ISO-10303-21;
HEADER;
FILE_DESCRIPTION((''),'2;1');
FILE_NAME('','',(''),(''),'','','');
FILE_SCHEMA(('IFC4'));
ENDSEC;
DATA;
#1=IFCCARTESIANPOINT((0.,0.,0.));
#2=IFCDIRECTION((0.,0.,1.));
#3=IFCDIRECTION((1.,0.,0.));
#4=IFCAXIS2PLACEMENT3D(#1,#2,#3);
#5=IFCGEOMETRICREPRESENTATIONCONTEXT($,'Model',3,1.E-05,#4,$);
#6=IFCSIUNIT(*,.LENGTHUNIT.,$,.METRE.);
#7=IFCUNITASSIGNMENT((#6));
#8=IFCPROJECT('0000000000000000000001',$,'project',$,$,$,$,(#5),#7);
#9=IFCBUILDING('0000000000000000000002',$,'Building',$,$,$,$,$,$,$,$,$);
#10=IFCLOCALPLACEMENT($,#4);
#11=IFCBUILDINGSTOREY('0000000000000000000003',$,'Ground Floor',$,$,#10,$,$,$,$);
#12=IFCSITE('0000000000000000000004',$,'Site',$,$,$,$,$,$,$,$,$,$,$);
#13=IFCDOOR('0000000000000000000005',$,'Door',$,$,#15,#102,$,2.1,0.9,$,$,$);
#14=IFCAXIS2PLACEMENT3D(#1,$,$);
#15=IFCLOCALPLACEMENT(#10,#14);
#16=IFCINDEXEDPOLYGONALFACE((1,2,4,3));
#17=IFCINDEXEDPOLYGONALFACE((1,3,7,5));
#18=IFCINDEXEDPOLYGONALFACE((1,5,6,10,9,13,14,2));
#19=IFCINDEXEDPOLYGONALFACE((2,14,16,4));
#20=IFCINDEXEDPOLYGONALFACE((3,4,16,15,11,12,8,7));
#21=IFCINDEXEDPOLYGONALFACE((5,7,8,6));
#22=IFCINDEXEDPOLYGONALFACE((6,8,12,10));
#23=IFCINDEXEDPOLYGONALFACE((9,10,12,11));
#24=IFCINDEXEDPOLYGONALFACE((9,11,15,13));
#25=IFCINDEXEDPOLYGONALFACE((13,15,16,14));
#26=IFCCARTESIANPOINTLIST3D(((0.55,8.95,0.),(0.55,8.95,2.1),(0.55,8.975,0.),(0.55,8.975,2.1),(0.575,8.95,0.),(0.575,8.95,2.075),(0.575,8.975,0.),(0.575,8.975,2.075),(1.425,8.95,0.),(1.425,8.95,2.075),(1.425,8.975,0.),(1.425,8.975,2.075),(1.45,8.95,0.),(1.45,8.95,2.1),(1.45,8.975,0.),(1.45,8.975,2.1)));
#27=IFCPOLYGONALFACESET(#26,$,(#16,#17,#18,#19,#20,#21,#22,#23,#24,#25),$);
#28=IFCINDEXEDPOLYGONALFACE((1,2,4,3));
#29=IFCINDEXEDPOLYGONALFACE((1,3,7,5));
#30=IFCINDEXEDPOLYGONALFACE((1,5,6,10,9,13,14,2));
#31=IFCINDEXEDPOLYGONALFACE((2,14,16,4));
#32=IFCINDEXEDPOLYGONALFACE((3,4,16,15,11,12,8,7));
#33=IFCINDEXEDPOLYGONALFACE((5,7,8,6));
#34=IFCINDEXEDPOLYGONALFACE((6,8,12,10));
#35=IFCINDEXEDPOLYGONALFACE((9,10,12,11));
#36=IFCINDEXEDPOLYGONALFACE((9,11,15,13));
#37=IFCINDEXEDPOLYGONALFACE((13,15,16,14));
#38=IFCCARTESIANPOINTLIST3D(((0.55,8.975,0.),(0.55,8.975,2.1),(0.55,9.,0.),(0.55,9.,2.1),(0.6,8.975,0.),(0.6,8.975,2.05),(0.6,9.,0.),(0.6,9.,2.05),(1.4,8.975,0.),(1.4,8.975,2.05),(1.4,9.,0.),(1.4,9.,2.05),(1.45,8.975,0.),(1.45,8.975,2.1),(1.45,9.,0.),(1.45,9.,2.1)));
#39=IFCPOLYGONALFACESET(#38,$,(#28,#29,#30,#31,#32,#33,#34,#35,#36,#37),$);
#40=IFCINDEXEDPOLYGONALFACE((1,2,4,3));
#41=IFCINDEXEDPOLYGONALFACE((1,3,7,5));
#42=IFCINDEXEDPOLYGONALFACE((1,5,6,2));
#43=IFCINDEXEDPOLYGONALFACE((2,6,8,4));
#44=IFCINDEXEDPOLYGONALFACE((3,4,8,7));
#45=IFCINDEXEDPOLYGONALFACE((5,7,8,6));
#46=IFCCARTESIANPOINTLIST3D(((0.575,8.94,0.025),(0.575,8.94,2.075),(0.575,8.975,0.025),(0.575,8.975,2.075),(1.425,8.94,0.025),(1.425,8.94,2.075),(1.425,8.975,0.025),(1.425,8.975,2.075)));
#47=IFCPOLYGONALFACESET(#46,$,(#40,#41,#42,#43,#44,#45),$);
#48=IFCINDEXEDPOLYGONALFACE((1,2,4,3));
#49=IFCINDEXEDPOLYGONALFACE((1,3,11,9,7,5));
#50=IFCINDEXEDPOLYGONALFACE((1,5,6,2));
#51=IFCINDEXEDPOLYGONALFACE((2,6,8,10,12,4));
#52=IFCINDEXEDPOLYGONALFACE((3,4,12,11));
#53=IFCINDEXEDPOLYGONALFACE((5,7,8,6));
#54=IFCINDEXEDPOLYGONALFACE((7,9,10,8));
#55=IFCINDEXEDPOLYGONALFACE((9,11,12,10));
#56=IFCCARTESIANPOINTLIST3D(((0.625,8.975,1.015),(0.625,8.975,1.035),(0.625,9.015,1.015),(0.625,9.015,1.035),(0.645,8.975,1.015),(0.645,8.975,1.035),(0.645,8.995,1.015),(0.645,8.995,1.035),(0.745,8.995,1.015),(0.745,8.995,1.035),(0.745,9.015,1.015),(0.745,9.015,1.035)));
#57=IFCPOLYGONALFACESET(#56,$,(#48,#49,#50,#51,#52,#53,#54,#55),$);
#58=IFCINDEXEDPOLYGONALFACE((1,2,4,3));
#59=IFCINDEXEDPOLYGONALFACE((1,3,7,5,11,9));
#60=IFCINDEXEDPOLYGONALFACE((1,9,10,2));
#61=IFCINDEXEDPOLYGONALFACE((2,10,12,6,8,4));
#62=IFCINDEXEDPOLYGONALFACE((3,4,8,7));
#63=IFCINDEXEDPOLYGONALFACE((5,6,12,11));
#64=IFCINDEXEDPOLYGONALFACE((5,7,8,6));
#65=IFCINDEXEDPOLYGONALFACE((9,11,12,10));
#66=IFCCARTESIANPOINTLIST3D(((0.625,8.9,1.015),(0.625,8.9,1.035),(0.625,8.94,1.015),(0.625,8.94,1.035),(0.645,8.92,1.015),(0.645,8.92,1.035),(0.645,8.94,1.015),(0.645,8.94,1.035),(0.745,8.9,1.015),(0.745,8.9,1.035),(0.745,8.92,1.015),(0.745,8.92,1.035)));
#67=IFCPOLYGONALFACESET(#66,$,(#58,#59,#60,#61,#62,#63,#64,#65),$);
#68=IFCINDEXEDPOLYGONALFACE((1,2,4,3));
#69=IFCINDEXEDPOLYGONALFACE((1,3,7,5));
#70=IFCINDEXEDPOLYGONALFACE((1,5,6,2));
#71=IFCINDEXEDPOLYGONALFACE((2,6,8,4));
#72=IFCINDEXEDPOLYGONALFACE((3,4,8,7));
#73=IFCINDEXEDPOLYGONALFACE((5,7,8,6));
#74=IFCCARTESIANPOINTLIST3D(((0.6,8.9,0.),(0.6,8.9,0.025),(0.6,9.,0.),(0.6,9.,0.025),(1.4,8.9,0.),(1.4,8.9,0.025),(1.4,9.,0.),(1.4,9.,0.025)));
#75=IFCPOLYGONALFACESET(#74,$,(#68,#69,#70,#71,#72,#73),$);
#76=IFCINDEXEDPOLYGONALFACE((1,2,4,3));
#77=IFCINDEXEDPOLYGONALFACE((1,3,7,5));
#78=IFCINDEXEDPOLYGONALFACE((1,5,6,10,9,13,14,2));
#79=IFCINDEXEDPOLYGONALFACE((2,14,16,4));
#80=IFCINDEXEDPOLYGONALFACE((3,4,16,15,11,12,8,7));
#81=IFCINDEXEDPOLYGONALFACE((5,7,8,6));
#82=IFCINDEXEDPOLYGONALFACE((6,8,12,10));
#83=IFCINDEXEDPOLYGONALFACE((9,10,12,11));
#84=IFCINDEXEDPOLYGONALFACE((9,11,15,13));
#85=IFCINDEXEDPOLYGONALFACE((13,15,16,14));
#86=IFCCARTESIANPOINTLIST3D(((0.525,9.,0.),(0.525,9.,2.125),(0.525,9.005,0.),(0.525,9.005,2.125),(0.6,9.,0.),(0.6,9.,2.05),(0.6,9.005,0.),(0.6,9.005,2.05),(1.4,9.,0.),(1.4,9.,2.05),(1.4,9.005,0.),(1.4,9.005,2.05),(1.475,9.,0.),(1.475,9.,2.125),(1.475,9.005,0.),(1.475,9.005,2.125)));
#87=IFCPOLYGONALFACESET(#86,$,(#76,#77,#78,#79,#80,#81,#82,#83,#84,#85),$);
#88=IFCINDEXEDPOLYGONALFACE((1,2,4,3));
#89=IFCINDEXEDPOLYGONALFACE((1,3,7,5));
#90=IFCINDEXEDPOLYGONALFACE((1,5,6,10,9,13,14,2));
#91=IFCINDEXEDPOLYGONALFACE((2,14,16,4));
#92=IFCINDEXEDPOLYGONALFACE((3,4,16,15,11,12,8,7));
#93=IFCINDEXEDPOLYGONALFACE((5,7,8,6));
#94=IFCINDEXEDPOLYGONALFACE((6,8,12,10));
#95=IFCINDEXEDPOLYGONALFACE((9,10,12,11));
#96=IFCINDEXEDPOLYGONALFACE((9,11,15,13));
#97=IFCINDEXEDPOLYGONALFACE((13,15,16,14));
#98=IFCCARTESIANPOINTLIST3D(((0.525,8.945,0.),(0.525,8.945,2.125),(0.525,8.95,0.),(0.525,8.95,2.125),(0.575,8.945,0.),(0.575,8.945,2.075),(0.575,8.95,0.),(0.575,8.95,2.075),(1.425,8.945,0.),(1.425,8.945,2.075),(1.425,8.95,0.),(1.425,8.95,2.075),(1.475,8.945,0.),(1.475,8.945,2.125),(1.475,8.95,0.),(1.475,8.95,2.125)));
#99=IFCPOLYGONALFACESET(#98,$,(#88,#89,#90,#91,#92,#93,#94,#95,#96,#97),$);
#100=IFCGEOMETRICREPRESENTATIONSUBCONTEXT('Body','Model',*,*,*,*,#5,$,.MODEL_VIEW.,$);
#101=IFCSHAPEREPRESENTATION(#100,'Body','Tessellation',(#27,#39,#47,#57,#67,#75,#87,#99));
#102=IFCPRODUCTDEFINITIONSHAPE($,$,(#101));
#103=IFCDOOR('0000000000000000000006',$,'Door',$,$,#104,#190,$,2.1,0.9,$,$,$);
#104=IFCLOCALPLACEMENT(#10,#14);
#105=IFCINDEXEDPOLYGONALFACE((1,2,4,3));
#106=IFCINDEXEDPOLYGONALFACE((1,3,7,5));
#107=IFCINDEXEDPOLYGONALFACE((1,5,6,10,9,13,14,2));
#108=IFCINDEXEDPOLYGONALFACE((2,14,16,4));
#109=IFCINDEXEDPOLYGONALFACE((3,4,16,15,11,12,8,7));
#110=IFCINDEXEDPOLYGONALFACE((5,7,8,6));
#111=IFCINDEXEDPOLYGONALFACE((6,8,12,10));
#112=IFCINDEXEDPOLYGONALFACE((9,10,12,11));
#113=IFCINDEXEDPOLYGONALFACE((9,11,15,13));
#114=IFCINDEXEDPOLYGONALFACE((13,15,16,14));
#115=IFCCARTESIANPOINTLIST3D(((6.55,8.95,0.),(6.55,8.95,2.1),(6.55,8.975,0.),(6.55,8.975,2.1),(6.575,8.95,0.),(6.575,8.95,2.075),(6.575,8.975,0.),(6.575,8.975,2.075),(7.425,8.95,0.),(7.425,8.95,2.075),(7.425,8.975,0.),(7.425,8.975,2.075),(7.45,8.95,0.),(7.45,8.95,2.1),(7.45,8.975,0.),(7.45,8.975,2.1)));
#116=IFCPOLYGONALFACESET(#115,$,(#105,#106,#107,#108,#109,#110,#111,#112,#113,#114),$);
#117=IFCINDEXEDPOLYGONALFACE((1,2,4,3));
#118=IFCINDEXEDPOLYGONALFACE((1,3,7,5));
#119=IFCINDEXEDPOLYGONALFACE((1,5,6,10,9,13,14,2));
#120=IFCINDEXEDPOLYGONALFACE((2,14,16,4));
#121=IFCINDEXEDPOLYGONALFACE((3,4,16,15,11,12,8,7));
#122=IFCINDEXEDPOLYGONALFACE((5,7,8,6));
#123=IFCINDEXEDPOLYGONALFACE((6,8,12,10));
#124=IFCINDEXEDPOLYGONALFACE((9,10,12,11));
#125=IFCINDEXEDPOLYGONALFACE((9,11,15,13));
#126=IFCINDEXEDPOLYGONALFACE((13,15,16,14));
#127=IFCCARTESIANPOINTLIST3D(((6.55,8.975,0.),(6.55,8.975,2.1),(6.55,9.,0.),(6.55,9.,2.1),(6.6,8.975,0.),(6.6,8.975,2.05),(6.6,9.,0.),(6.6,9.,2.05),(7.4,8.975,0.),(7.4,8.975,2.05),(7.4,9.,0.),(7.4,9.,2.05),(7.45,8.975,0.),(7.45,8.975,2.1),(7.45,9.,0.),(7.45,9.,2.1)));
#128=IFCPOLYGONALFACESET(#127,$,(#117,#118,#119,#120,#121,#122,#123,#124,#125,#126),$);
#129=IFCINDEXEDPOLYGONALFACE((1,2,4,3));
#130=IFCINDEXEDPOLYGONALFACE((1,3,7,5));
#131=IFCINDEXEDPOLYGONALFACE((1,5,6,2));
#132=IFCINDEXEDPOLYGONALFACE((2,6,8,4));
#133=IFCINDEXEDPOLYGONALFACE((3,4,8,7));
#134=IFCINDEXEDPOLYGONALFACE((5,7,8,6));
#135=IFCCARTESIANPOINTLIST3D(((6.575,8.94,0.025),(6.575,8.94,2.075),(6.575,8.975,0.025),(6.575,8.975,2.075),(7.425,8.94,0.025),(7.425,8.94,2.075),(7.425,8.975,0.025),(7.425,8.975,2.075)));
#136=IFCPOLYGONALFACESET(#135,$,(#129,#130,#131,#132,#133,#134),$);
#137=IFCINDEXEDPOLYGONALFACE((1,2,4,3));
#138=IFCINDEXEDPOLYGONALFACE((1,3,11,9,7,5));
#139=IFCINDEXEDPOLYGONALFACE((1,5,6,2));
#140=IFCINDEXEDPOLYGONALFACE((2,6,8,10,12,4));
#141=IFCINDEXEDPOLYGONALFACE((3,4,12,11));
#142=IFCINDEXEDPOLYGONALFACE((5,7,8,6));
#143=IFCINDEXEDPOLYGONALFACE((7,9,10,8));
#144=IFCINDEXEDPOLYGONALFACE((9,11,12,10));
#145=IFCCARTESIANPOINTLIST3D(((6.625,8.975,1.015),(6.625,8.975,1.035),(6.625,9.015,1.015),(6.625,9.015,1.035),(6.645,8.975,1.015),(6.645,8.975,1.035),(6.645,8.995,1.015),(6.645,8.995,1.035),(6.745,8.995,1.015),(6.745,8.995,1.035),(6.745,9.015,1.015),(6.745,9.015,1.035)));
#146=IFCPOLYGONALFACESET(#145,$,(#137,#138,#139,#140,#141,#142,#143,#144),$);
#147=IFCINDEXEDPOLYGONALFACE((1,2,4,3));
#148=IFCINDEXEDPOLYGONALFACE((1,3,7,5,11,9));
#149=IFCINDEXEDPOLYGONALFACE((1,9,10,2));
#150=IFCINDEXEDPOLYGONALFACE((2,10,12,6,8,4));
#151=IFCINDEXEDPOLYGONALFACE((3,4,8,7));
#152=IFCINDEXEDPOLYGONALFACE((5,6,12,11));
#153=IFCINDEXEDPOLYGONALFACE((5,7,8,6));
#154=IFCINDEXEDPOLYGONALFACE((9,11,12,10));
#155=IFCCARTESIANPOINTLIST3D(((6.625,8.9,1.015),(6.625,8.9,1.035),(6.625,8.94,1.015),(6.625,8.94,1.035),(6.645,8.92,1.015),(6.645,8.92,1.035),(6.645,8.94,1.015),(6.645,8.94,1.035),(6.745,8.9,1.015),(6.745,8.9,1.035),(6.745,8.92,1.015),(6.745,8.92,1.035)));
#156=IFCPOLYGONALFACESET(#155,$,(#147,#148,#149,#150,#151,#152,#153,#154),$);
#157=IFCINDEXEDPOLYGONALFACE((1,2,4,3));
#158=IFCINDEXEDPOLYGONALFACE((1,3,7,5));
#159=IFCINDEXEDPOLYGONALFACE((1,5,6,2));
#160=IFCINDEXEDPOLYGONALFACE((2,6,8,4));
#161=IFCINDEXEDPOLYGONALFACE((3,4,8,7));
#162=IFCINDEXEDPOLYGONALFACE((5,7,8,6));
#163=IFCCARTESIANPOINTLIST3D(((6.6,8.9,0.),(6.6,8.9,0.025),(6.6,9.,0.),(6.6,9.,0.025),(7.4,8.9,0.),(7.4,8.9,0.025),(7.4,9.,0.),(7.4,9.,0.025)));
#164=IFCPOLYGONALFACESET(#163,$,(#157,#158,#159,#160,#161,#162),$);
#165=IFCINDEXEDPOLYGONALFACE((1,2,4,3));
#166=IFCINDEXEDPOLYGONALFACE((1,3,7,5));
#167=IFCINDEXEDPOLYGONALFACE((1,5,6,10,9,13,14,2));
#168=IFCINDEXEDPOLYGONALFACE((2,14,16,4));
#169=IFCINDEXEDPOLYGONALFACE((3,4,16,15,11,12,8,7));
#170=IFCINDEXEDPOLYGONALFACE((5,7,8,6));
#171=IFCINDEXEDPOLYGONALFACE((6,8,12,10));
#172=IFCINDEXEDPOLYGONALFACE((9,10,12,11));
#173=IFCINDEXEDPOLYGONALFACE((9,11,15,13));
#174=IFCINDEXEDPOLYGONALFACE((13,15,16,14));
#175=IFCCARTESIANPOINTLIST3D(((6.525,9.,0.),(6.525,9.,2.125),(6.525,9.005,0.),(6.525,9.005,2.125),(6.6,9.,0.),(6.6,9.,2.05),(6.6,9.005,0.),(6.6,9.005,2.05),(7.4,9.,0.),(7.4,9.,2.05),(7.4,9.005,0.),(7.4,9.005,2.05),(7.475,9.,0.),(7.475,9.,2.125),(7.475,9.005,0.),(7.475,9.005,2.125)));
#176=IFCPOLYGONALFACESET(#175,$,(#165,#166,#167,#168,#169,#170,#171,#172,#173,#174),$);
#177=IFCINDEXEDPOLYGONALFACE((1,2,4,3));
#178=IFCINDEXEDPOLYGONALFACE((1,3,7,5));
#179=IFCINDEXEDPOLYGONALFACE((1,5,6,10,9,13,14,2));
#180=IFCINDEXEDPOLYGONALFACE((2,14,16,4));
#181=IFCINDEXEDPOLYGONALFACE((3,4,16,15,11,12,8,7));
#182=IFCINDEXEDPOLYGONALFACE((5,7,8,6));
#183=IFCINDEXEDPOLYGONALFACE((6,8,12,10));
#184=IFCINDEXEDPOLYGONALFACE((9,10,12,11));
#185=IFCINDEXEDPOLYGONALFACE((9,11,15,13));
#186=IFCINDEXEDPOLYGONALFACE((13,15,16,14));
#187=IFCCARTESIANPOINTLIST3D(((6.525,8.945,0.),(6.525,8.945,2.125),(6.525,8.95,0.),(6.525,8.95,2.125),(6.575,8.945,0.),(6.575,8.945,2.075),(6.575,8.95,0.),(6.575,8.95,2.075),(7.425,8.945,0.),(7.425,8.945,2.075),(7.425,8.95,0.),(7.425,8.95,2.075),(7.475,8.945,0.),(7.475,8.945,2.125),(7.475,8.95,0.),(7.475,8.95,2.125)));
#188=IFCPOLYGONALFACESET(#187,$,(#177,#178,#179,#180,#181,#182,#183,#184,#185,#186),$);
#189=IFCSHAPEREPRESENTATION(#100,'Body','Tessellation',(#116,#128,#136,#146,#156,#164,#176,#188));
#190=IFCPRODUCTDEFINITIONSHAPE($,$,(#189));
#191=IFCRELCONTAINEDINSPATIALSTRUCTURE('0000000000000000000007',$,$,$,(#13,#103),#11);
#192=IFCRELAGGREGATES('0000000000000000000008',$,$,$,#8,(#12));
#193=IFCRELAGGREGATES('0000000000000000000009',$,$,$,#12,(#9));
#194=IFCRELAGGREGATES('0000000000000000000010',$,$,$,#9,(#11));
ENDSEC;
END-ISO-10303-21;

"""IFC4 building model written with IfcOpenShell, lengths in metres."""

from ifc_helpers import new_model, si_unit, frame, origin_with_axes, place, context, subcontext, project, spatial, line, indexed_curve, outline, extrude, element, save


model = new_model("IFC4")

# Units and contexts
model_context = context("Model", 3, precision=1e-05, world=origin_with_axes())
body_context = subcontext(model_context, "Body", "Model", "MODEL_VIEW")
ifc_project = project(units=[si_unit("LENGTHUNIT", "METRE")], contexts=[model_context])

# Site, building, storey
site = spatial("IfcSite", under=ifc_project, Name="Site")
building = spatial("IfcBuilding", under=site, Name="Building")
storey_placement = place(None, origin_with_axes())
storey = spatial("IfcBuildingStorey", under=building, at=storey_placement, Name="Ground Floor")

# Doors
door_1_placement = place(storey_placement, frame((1.45, 9.0, 0.0), z_axis=(0.0, 0.0, 1.0), x_axis=(-1.0, 0.0, 0.0)))
element("IfcDoor", 1, at=door_1_placement, inside=storey, Name="Door", OverallHeight=2.1, OverallWidth=0.9, context=body_context, shape_type="SweptSolid", body=[
    extrude(outline(indexed_curve([(0.0, 0.0), (0.0, 2.1), (0.9, 2.1), (0.9, 0.0), (0.875, 0.0), (0.875, 2.075), (0.025, 2.075), (0.025, 0.0)], segments=[line(1, 2, 3, 4, 5, 6, 7, 8, 1)])), frame((0.0, 0.025, 0.0), z_axis=(0.0, -1.0, 0.0), x_axis=(1.0, 0.0, 0.0)), (0.0, 0.0, -1.0), 0.025),
    extrude(outline(indexed_curve([(0.0, 0.0), (0.0, 2.1), (0.9, 2.1), (0.9, 0.0), (0.85, 0.0), (0.85, 2.05), (0.05, 2.05), (0.05, 0.0)], segments=[line(1, 2, 3, 4, 5, 6, 7, 8, 1)])), frame((0.0, 0.0, 0.0), z_axis=(0.0, -1.0, 0.0), x_axis=(1.0, 0.0, 0.0)), (0.0, 0.0, -1.0), 0.025),
    extrude(outline(indexed_curve([(0.0, 0.0), (0.85, 0.0), (0.85, 0.035), (0.0, 0.035)], segments=[line(1, 2, 3, 4, 1)])), frame((0.025, 0.025, 0.025), z_axis=(0.0, 0.0, 1.0), x_axis=(1.0, 0.0, 0.0)), (0.0, 0.0, 1.0), 2.05),
    extrude(outline(indexed_curve([(0.0, 0.0), (0.0, -0.04), (-0.12, -0.04), (-0.12, -0.02), (-0.02, -0.02), (-0.02, 0.0)], segments=[line(1, 2, 3, 4, 5, 6, 1)])), frame((0.825, 0.025, 1.015), z_axis=(0.0, 0.0, 1.0), x_axis=(1.0, 0.0, 0.0)), (0.0, 0.0, 1.0), 0.02),
    extrude(outline(indexed_curve([(0.0, 0.0), (0.0, 0.04), (-0.12, 0.04), (-0.12, 0.02), (-0.02, 0.02), (-0.02, 0.0)], segments=[line(1, 2, 3, 4, 5, 6, 1)])), frame((0.825, 0.06, 1.015), z_axis=(0.0, 0.0, 1.0), x_axis=(1.0, 0.0, 0.0)), (0.0, 0.0, 1.0), 0.02),
    extrude(outline(indexed_curve([(0.0, 0.0), (0.8, 0.0), (0.8, 0.1), (0.0, 0.1)], segments=[line(1, 2, 3, 4, 1)])), frame((0.05, 0.0, 0.0), z_axis=(0.0, 0.0, 1.0), x_axis=(1.0, 0.0, 0.0)), (0.0, 0.0, 1.0), 0.025),
    extrude(outline(indexed_curve([(0.0, 0.0), (0.0, 2.125), (0.95, 2.125), (0.95, 0.0), (0.875, 0.0), (0.875, 2.05), (0.075, 2.05), (0.075, 0.0)], segments=[line(1, 2, 3, 4, 5, 6, 7, 8, 1)])), frame((-0.025, -0.005, 0.0), z_axis=(0.0, -1.0, 0.0), x_axis=(1.0, 0.0, 0.0)), (0.0, 0.0, -1.0), 0.005),
    extrude(outline(indexed_curve([(0.0, 0.0), (0.0, 2.125), (0.95, 2.125), (0.95, 0.0), (0.9, 0.0), (0.9, 2.075), (0.05, 2.075), (0.05, 0.0)], segments=[line(1, 2, 3, 4, 5, 6, 7, 8, 1)])), frame((-0.025, 0.05, 0.0), z_axis=(0.0, -1.0, 0.0), x_axis=(1.0, 0.0, 0.0)), (0.0, 0.0, -1.0), 0.005),
])
door_2_placement = place(storey_placement, frame((7.45, 9.0, 0.0), z_axis=(0.0, 0.0, 1.0), x_axis=(-1.0, 0.0, 0.0)))
element("IfcDoor", 2, at=door_2_placement, inside=storey, Name="Door", OverallHeight=2.1, OverallWidth=0.9, context=body_context, shape_type="SweptSolid", body=[
    extrude(outline(indexed_curve([(0.0, 0.0), (0.0, 2.1), (0.9, 2.1), (0.9, 0.0), (0.875, 0.0), (0.875, 2.075), (0.025, 2.075), (0.025, 0.0)], segments=[line(1, 2, 3, 4, 5, 6, 7, 8, 1)])), frame((0.0, 0.025, 0.0), z_axis=(0.0, -1.0, 0.0), x_axis=(1.0, 0.0, 0.0)), (0.0, 0.0, -1.0), 0.025),
    extrude(outline(indexed_curve([(0.0, 0.0), (0.0, 2.1), (0.9, 2.1), (0.9, 0.0), (0.85, 0.0), (0.85, 2.05), (0.05, 2.05), (0.05, 0.0)], segments=[line(1, 2, 3, 4, 5, 6, 7, 8, 1)])), frame((0.0, 0.0, 0.0), z_axis=(0.0, -1.0, 0.0), x_axis=(1.0, 0.0, 0.0)), (0.0, 0.0, -1.0), 0.025),
    extrude(outline(indexed_curve([(0.0, 0.0), (0.85, 0.0), (0.85, 0.035), (0.0, 0.035)], segments=[line(1, 2, 3, 4, 1)])), frame((0.025, 0.025, 0.025), z_axis=(0.0, 0.0, 1.0), x_axis=(1.0, 0.0, 0.0)), (0.0, 0.0, 1.0), 2.05),
    extrude(outline(indexed_curve([(0.0, 0.0), (0.0, -0.04), (-0.12, -0.04), (-0.12, -0.02), (-0.02, -0.02), (-0.02, 0.0)], segments=[line(1, 2, 3, 4, 5, 6, 1)])), frame((0.825, 0.025, 1.015), z_axis=(0.0, 0.0, 1.0), x_axis=(1.0, 0.0, 0.0)), (0.0, 0.0, 1.0), 0.02),
    extrude(outline(indexed_curve([(0.0, 0.0), (0.0, 0.04), (-0.12, 0.04), (-0.12, 0.02), (-0.02, 0.02), (-0.02, 0.0)], segments=[line(1, 2, 3, 4, 5, 6, 1)])), frame((0.825, 0.06, 1.015), z_axis=(0.0, 0.0, 1.0), x_axis=(1.0, 0.0, 0.0)), (0.0, 0.0, 1.0), 0.02),
    extrude(outline(indexed_curve([(0.0, 0.0), (0.8, 0.0), (0.8, 0.1), (0.0, 0.1)], segments=[line(1, 2, 3, 4, 1)])), frame((0.05, 0.0, 0.0), z_axis=(0.0, 0.0, 1.0), x_axis=(1.0, 0.0, 0.0)), (0.0, 0.0, 1.0), 0.025),
    extrude(outline(indexed_curve([(0.0, 0.0), (0.0, 2.125), (0.95, 2.125), (0.95, 0.0), (0.875, 0.0), (0.875, 2.05), (0.075, 2.05), (0.075, 0.0)], segments=[line(1, 2, 3, 4, 5, 6, 7, 8, 1)])), frame((-0.025, -0.005, 0.0), z_axis=(0.0, -1.0, 0.0), x_axis=(1.0, 0.0, 0.0)), (0.0, 0.0, -1.0), 0.005),
    extrude(outline(indexed_curve([(0.0, 0.0), (0.0, 2.125), (0.95, 2.125), (0.95, 0.0), (0.9, 0.0), (0.9, 2.075), (0.05, 2.075), (0.05, 0.0)], segments=[line(1, 2, 3, 4, 5, 6, 7, 8, 1)])), frame((-0.025, 0.05, 0.0), z_axis=(0.0, -1.0, 0.0), x_axis=(1.0, 0.0, 0.0)), (0.0, 0.0, -1.0), 0.005),
])

save(model, "model.ifc")
